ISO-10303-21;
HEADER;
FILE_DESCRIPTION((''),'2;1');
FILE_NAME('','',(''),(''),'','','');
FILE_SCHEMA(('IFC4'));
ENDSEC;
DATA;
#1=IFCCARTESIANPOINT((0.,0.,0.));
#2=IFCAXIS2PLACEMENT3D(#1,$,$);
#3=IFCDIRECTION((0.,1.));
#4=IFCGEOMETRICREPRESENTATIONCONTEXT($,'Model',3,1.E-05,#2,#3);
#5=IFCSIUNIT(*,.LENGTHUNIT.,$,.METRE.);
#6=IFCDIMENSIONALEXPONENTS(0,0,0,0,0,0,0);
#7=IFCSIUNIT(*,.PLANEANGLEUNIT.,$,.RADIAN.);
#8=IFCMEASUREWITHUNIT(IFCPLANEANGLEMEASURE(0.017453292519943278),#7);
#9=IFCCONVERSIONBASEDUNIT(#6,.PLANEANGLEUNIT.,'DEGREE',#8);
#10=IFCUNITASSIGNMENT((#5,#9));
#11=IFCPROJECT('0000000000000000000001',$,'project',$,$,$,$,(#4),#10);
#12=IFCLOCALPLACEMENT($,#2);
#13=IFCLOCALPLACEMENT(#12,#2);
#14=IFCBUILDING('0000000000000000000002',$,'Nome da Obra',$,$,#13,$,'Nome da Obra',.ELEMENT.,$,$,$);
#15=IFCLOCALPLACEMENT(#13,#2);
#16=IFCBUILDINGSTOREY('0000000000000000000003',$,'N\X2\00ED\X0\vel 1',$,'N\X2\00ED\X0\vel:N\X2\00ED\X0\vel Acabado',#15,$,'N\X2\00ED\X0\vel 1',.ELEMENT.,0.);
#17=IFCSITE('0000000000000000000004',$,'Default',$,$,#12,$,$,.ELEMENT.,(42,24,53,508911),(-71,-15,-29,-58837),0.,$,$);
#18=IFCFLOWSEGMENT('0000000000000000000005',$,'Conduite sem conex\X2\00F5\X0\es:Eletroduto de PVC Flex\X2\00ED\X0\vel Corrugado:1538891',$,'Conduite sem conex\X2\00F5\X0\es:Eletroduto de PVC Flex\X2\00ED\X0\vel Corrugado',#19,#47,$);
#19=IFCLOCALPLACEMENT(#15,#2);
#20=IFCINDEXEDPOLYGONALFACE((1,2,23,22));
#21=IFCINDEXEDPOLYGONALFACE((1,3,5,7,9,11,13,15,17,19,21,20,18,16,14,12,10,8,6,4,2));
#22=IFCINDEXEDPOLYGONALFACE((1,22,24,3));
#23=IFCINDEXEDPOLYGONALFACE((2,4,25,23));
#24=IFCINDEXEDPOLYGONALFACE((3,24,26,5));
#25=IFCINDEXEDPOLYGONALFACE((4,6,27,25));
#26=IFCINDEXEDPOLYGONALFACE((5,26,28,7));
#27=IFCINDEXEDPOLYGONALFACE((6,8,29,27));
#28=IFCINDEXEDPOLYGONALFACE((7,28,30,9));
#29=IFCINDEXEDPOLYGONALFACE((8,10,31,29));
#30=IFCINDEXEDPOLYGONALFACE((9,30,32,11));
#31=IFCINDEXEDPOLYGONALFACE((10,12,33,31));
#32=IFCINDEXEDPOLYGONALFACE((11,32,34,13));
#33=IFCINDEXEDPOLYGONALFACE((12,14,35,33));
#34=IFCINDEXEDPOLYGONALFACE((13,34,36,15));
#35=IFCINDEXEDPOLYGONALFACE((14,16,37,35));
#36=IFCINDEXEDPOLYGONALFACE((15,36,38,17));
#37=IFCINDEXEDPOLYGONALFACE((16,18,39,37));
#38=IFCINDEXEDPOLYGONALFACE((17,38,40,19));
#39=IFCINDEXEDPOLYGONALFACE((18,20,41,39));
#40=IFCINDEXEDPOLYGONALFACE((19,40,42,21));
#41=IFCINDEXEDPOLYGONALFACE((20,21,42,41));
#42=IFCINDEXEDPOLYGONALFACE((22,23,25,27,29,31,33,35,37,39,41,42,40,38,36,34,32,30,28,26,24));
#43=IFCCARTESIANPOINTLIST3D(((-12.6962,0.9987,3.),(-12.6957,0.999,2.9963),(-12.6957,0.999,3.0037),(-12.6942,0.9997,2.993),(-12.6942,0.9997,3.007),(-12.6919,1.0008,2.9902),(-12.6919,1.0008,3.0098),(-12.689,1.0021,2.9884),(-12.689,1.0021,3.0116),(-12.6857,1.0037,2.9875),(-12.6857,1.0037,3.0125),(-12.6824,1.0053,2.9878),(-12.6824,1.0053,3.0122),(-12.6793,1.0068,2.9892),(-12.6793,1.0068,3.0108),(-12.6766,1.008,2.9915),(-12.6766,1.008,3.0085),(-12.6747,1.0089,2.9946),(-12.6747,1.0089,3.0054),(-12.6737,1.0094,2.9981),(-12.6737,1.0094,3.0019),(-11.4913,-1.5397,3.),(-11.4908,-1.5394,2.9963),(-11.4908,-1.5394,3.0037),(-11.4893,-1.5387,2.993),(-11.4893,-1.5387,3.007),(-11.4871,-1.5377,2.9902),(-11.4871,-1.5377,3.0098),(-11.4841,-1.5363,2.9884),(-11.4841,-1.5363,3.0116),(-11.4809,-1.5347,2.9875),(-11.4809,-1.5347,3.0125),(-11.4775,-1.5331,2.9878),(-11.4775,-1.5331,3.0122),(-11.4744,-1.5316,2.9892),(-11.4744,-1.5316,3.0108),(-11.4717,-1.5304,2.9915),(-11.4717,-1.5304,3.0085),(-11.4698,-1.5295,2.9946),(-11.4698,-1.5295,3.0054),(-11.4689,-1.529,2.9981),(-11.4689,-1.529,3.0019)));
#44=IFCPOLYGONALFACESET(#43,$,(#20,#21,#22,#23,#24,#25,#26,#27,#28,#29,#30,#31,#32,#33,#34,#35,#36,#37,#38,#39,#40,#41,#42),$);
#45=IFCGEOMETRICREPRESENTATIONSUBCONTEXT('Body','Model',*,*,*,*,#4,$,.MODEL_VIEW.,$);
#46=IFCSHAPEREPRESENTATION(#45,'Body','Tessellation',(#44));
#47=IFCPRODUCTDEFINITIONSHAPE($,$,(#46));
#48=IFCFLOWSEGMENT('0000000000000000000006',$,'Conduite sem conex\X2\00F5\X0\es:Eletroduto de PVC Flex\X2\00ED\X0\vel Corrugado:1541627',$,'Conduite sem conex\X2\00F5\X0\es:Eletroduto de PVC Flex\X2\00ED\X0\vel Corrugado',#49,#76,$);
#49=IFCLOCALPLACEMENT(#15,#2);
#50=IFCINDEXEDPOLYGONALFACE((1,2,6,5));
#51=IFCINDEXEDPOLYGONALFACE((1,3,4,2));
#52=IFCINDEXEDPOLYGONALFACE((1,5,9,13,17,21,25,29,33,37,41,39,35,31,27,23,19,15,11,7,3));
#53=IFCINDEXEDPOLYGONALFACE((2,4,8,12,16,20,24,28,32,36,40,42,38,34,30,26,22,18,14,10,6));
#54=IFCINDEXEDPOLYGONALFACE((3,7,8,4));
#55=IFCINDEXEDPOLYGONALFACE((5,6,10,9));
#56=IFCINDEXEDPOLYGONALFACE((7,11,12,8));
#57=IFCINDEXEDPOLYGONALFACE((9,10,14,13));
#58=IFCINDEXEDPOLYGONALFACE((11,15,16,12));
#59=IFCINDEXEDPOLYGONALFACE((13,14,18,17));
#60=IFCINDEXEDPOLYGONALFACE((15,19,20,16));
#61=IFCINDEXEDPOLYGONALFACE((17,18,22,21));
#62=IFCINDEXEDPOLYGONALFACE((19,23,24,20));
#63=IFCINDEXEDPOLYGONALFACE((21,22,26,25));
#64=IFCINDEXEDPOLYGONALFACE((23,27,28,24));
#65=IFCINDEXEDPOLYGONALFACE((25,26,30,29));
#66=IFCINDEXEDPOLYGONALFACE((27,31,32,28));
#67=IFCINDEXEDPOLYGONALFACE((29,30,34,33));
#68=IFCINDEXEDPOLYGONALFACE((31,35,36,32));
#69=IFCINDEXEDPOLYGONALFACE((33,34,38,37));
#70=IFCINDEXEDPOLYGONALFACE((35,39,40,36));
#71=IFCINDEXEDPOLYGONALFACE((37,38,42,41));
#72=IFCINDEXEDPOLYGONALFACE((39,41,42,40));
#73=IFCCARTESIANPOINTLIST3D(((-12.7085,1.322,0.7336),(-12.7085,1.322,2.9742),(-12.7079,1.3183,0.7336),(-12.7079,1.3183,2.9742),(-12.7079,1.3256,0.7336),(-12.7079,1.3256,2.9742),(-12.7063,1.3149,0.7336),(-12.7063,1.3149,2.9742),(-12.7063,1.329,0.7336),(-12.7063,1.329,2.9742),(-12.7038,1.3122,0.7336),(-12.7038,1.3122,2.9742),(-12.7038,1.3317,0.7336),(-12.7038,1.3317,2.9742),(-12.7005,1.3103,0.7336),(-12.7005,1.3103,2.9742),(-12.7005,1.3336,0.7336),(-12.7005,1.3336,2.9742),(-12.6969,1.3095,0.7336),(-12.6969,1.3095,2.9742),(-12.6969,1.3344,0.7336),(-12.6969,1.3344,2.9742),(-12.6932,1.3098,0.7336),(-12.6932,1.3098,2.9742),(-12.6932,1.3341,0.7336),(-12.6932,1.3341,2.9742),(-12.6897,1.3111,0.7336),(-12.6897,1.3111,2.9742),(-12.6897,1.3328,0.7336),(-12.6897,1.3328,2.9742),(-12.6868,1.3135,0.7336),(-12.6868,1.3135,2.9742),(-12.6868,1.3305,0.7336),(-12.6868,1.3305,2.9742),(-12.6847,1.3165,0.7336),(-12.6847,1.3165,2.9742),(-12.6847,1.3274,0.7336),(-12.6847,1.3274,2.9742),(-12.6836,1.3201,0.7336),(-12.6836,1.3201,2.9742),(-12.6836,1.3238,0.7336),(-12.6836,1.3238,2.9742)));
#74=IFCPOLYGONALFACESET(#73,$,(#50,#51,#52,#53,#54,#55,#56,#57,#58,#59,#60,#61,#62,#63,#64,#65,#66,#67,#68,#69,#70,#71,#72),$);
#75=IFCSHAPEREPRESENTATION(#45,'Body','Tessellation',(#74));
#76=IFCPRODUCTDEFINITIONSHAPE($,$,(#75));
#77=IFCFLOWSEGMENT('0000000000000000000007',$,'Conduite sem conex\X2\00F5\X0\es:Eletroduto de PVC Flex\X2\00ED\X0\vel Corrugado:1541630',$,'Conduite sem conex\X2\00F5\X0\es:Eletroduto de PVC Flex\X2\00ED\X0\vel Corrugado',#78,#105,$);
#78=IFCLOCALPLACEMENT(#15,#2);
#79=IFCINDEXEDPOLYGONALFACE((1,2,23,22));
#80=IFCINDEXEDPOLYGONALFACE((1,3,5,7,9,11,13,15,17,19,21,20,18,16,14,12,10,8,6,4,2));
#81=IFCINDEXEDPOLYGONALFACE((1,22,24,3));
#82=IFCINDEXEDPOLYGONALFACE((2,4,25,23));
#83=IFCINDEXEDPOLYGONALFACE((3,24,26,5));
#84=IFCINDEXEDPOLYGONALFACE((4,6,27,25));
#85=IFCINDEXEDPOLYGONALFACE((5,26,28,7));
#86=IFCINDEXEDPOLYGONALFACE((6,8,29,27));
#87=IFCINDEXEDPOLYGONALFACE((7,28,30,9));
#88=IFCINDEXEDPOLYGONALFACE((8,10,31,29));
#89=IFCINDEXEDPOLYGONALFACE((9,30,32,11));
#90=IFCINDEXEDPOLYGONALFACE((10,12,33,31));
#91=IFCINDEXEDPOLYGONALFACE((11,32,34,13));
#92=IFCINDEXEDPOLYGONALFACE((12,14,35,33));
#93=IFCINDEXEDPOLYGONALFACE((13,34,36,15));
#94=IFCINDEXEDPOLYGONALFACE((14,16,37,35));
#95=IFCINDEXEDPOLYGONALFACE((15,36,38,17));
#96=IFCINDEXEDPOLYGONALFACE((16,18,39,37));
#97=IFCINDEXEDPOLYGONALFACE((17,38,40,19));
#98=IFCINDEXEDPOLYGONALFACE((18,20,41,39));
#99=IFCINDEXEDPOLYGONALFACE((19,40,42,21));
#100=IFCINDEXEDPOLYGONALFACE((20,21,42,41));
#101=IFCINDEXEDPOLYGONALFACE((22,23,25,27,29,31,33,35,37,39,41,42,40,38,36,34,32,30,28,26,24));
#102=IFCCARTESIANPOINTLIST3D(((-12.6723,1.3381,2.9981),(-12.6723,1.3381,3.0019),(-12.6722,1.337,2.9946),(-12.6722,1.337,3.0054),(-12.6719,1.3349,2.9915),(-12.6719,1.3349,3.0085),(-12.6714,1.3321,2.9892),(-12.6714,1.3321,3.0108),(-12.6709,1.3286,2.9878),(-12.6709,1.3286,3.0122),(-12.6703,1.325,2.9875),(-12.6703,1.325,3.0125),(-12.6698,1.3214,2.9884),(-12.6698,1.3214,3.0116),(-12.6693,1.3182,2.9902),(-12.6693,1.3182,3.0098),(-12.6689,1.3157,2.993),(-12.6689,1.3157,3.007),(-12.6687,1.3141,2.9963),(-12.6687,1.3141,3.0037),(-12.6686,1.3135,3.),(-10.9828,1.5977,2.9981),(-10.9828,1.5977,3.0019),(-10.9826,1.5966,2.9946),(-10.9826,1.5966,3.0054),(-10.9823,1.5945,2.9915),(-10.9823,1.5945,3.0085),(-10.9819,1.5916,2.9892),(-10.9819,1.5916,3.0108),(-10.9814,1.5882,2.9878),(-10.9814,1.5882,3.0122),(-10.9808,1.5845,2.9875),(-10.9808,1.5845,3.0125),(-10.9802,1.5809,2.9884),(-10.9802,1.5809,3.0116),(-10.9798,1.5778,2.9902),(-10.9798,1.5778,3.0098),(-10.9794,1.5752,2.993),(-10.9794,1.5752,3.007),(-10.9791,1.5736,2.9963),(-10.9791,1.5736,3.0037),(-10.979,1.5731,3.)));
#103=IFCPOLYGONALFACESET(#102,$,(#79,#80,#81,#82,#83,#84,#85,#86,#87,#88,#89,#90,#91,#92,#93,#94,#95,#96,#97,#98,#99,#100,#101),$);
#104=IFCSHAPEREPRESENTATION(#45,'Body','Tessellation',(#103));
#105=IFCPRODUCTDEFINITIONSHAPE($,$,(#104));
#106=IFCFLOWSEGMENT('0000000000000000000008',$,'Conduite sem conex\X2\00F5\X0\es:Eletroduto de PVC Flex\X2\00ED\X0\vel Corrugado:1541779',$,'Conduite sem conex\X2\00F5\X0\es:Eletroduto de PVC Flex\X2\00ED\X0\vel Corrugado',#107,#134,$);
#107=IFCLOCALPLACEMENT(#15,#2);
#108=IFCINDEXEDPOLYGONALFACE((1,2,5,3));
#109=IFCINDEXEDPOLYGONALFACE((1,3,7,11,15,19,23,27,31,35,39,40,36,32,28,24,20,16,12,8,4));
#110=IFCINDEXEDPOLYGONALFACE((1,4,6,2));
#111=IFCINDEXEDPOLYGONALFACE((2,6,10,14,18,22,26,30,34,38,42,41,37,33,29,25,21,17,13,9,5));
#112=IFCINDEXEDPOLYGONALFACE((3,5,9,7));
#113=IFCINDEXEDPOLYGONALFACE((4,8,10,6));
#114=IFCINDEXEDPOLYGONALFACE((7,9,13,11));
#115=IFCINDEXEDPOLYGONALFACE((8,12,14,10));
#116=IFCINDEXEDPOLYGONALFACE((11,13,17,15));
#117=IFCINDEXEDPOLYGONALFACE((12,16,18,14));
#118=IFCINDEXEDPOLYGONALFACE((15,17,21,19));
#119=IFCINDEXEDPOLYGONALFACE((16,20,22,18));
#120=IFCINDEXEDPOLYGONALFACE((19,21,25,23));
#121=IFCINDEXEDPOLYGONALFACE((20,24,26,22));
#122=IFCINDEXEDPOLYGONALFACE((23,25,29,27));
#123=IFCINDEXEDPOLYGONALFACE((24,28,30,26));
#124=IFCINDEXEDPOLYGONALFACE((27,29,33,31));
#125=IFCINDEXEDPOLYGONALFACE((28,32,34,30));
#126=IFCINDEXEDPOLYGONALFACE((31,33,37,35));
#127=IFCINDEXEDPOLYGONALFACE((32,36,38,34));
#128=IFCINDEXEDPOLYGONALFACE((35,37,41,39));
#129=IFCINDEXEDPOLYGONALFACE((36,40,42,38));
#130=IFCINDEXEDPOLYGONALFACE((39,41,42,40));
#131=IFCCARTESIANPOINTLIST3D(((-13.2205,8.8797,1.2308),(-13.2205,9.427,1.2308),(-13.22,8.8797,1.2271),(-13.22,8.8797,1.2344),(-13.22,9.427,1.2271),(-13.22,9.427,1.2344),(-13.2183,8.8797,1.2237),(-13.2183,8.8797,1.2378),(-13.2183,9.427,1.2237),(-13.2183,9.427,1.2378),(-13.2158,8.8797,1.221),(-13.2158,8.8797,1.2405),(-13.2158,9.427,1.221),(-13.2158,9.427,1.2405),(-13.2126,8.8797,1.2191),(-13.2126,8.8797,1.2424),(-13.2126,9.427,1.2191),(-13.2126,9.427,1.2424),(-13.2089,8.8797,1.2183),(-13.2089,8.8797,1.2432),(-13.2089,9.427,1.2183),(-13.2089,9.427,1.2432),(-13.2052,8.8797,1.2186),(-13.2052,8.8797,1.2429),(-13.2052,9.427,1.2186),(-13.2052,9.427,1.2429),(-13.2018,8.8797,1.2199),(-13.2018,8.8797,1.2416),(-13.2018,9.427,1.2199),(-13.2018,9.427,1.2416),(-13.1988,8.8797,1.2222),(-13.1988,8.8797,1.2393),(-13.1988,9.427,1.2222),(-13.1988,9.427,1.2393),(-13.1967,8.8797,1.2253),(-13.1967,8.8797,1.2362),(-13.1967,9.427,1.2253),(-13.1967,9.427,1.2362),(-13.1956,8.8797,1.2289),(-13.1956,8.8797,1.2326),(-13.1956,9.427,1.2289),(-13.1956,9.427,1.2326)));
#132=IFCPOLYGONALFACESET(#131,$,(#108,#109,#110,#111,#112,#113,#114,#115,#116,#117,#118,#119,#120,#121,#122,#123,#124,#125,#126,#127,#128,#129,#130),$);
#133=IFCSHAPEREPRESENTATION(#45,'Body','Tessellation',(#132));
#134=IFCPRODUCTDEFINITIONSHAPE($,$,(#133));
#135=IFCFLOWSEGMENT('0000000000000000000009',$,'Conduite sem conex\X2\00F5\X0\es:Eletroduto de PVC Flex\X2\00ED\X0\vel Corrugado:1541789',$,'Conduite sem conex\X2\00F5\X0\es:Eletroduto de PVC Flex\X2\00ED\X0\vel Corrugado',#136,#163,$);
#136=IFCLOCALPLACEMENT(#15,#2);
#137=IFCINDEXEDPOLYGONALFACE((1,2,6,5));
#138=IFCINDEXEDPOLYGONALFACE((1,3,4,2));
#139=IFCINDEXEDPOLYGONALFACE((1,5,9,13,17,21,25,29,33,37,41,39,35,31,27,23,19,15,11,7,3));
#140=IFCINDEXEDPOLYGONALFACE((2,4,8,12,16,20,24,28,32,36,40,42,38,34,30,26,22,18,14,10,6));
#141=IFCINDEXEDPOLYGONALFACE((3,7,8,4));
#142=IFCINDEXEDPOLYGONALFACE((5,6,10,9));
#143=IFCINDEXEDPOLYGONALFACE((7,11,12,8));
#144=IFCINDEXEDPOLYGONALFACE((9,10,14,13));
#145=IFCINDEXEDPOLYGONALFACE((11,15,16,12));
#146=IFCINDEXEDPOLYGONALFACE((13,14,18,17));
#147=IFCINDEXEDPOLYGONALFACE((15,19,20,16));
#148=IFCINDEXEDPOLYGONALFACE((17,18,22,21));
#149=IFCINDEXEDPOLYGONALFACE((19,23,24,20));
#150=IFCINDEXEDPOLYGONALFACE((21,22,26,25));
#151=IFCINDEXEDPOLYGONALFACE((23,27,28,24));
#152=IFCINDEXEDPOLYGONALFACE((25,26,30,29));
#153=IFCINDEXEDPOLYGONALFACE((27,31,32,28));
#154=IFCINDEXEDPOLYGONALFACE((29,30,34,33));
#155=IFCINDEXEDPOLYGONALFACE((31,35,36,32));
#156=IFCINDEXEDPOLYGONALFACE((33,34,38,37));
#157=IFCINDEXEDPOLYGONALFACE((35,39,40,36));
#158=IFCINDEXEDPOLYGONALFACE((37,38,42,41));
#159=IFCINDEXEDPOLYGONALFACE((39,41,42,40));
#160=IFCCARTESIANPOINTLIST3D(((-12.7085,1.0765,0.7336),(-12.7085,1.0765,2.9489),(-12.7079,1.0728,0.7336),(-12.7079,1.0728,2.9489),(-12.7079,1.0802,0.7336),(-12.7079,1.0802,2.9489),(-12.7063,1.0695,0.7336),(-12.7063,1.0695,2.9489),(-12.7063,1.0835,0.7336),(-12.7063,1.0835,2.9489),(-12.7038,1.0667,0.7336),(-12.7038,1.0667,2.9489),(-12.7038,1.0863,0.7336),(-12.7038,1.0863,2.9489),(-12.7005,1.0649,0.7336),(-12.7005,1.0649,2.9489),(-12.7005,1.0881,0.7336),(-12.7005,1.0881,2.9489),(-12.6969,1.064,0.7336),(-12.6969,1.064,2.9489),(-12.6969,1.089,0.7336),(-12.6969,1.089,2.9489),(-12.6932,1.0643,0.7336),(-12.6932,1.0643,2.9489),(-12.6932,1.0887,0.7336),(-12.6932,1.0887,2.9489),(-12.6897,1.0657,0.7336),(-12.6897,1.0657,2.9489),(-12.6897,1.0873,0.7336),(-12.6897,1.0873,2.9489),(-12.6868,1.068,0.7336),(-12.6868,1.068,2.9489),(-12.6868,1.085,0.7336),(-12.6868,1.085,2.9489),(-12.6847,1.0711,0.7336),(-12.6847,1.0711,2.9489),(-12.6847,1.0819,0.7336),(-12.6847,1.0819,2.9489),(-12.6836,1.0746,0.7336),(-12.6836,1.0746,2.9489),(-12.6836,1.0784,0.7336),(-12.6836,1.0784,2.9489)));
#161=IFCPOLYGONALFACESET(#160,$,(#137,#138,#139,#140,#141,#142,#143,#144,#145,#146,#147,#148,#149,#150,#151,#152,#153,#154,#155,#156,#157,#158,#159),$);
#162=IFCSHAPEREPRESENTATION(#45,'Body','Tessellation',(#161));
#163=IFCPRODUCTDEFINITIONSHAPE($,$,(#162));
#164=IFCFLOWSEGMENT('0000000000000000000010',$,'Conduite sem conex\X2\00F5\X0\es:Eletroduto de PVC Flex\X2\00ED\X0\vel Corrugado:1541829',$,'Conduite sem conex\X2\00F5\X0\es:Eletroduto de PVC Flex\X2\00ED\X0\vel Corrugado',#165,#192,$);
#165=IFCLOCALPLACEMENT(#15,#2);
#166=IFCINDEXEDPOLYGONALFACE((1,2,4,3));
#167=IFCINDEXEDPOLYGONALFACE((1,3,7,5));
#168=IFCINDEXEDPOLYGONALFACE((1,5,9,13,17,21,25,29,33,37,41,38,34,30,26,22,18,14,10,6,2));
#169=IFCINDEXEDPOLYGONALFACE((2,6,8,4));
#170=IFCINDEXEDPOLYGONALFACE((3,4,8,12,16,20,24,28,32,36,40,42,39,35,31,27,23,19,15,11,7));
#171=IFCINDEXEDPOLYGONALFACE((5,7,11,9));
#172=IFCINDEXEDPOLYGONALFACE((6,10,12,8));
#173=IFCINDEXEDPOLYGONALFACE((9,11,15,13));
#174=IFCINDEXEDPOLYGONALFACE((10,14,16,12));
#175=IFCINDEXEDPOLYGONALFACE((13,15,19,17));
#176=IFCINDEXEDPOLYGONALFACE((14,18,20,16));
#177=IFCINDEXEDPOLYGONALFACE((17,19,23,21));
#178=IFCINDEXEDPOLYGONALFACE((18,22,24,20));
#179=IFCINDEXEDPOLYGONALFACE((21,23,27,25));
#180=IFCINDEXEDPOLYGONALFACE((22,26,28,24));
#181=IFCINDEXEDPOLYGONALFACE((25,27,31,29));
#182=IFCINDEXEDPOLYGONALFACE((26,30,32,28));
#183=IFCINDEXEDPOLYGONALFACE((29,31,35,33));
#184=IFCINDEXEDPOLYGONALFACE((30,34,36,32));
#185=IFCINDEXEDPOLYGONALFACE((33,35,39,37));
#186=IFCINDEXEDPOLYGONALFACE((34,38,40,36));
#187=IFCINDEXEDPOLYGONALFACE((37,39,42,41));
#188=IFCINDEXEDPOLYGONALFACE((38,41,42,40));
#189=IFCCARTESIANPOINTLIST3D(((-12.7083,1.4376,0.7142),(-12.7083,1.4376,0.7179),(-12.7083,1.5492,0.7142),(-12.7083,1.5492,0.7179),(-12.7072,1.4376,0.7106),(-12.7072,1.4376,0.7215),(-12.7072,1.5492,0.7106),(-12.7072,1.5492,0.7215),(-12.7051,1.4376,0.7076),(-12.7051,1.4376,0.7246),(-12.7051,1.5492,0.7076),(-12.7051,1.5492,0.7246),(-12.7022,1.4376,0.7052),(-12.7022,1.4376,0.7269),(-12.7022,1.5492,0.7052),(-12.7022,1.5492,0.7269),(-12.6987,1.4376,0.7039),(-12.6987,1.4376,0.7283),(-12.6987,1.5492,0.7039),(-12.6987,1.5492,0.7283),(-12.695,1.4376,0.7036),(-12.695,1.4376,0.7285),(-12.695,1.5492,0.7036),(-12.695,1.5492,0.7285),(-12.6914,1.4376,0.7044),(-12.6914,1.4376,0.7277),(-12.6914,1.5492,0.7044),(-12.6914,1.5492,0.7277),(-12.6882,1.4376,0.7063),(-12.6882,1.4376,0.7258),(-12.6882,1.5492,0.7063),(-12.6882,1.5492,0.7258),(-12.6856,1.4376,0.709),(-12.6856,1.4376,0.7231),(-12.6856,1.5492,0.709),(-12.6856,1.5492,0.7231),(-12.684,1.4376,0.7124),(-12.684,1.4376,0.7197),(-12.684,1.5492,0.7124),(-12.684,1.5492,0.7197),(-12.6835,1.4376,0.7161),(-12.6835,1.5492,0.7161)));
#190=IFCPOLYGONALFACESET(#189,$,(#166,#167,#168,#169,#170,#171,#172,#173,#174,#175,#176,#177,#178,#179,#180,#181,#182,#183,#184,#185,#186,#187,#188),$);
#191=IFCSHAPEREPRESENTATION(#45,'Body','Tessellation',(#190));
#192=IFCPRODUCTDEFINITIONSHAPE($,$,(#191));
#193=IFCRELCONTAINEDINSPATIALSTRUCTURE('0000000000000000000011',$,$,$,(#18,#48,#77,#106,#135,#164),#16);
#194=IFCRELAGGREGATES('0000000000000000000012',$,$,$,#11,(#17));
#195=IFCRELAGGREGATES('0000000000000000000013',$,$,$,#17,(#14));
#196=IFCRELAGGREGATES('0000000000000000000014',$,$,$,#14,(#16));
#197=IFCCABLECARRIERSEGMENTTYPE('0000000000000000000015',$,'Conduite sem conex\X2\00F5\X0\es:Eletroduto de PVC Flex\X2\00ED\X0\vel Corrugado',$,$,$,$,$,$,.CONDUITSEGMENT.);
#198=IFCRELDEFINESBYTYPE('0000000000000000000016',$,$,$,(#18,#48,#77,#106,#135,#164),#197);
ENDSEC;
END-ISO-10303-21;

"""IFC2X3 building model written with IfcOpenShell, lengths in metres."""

from ifc_helpers import new_model, entity, si_unit, converted_unit, direction, frame, frame_2d, origin, origin_2d_with_axis, place, context, subcontext, project, spatial, circle, extrude, type_object, element, save


model = new_model("IFC2X3")

# Units and contexts
model_context = context("Model", 3, precision=1e-05, world=origin(), true_north=direction((0.0, 1.0)))
body_context = subcontext(model_context, "Body", "Model", "MODEL_VIEW")
ifc_project = project(units=[si_unit("LENGTHUNIT", "METRE"), converted_unit("PLANEANGLEUNIT", "DEGREE", entity("IfcPlaneAngleMeasure", 0.017453292519943278), si_unit("PLANEANGLEUNIT", "RADIAN"), dimensions=[0, 0, 0, 0, 0, 0, 0])], contexts=[model_context])

# Site, building, storey
site_placement = place(None, origin())
site = spatial("IfcSite", under=ifc_project, at=site_placement, Name="Default", CompositionType="ELEMENT", RefLatitude=(42, 24, 53, 508911), RefLongitude=(-71, -15, -29, -58837), RefElevation=0.0)
building_placement = place(site_placement, origin())
building = spatial("IfcBuilding", under=site, at=building_placement, Name="Nome da Obra", LongName="Nome da Obra", CompositionType="ELEMENT")
storey_placement = place(building_placement, origin())
storey = spatial("IfcBuildingStorey", under=building, at=storey_placement, Name="Nível 1", ObjectType="Nível:Nível Acabado", LongName="Nível 1", CompositionType="ELEMENT", Elevation=0.0)

# Flow segments
cable_carrier_segment_type = type_object("IfcCableCarrierSegmentType", Name="Conduite sem conexões:Eletroduto de PVC Flexível Corrugado", PredefinedType="CONDUITSEGMENT")
flow_segment_1_placement = place(storey_placement, origin())
element("IfcFlowSegment", 1, at=flow_segment_1_placement, inside=storey, type_object=cable_carrier_segment_type, Name="Conduite sem conexões:Eletroduto de PVC Flexível Corrugado:1538891", ObjectType="Conduite sem conexões:Eletroduto de PVC Flexível Corrugado", context=body_context, shape_type="SweptSolid", body=[
    extrude(circle(Radius=0.0125, at=frame_2d((0.0, 0.0), x_axis=(1.0, 0.0))), frame((-11.48, -1.5343, 3.0), z_axis=(-0.428806, 0.903397, 0.0), x_axis=(-0.903397, -0.428806, 0.0)), (0.0, 0.0, 1.0), 2.8099),
])
flow_segment_2_placement = place(storey_placement, origin())
element("IfcFlowSegment", 2, at=flow_segment_2_placement, inside=storey, type_object=cable_carrier_segment_type, Name="Conduite sem conexões:Eletroduto de PVC Flexível Corrugado:1541627", ObjectType="Conduite sem conexões:Eletroduto de PVC Flexível Corrugado", context=body_context, shape_type="SweptSolid", body=[
    extrude(circle(Radius=0.0125, at=origin_2d_with_axis()), frame((-12.696, 1.322, 0.7336), z_axis=(0.0, 0.0, 1.0), x_axis=(-1.0, 0.0, 0.0)), (0.0, 0.0, 1.0), 2.2406),
])
flow_segment_3_placement = place(storey_placement, origin())
element("IfcFlowSegment", 3, at=flow_segment_3_placement, inside=storey, type_object=cable_carrier_segment_type, Name="Conduite sem conexões:Eletroduto de PVC Flexível Corrugado:1541630", ObjectType="Conduite sem conexões:Eletroduto de PVC Flexível Corrugado", context=body_context, shape_type="SweptSolid", body=[
    extrude(circle(Radius=0.0125, at=origin_2d_with_axis()), frame((-12.6705, 1.3259, 3.0), z_axis=(0.988403, 0.151856, 0.0), x_axis=(0.151856, -0.988403, 0.0)), (0.0, 0.0, 1.0), 1.7094),
])
flow_segment_4_placement = place(storey_placement, origin())
element("IfcFlowSegment", 4, at=flow_segment_4_placement, inside=storey, type_object=cable_carrier_segment_type, Name="Conduite sem conexões:Eletroduto de PVC Flexível Corrugado:1541779", ObjectType="Conduite sem conexões:Eletroduto de PVC Flexível Corrugado", context=body_context, shape_type="SweptSolid", body=[
    extrude(circle(Radius=0.0125, at=frame_2d((0.0, 0.0), x_axis=(1.0, 0.0))), frame((-13.208, 8.8797, 1.2308), z_axis=(0.0, 1.0, 0.0), x_axis=(-1.0, 0.0, 0.0)), (0.0, 0.0, 1.0), 0.5473),
])
flow_segment_5_placement = place(storey_placement, origin())
element("IfcFlowSegment", 5, at=flow_segment_5_placement, inside=storey, type_object=cable_carrier_segment_type, Name="Conduite sem conexões:Eletroduto de PVC Flexível Corrugado:1541789", ObjectType="Conduite sem conexões:Eletroduto de PVC Flexível Corrugado", context=body_context, shape_type="SweptSolid", body=[
    extrude(circle(Radius=0.0125, at=frame_2d((0.0, 0.0), x_axis=(1.0, 0.0))), frame((-12.696, 1.0765, 0.7336), z_axis=(0.0, 0.0, 1.0), x_axis=(-1.0, 0.0, 0.0)), (0.0, 0.0, 1.0), 2.2154),
])
flow_segment_6_placement = place(storey_placement, origin())
element("IfcFlowSegment", 6, at=flow_segment_6_placement, inside=storey, type_object=cable_carrier_segment_type, Name="Conduite sem conexões:Eletroduto de PVC Flexível Corrugado:1541829", ObjectType="Conduite sem conexões:Eletroduto de PVC Flexível Corrugado", context=body_context, shape_type="SweptSolid", body=[
    extrude(circle(Radius=0.0125, at=origin_2d_with_axis()), frame((-12.696, 1.4376, 0.7161), z_axis=(0.0, 1.0, 0.0), x_axis=(1.0, 0.0, 0.0)), (0.0, 0.0, 1.0), 0.1116),
])

save(model, "model.ifc")
